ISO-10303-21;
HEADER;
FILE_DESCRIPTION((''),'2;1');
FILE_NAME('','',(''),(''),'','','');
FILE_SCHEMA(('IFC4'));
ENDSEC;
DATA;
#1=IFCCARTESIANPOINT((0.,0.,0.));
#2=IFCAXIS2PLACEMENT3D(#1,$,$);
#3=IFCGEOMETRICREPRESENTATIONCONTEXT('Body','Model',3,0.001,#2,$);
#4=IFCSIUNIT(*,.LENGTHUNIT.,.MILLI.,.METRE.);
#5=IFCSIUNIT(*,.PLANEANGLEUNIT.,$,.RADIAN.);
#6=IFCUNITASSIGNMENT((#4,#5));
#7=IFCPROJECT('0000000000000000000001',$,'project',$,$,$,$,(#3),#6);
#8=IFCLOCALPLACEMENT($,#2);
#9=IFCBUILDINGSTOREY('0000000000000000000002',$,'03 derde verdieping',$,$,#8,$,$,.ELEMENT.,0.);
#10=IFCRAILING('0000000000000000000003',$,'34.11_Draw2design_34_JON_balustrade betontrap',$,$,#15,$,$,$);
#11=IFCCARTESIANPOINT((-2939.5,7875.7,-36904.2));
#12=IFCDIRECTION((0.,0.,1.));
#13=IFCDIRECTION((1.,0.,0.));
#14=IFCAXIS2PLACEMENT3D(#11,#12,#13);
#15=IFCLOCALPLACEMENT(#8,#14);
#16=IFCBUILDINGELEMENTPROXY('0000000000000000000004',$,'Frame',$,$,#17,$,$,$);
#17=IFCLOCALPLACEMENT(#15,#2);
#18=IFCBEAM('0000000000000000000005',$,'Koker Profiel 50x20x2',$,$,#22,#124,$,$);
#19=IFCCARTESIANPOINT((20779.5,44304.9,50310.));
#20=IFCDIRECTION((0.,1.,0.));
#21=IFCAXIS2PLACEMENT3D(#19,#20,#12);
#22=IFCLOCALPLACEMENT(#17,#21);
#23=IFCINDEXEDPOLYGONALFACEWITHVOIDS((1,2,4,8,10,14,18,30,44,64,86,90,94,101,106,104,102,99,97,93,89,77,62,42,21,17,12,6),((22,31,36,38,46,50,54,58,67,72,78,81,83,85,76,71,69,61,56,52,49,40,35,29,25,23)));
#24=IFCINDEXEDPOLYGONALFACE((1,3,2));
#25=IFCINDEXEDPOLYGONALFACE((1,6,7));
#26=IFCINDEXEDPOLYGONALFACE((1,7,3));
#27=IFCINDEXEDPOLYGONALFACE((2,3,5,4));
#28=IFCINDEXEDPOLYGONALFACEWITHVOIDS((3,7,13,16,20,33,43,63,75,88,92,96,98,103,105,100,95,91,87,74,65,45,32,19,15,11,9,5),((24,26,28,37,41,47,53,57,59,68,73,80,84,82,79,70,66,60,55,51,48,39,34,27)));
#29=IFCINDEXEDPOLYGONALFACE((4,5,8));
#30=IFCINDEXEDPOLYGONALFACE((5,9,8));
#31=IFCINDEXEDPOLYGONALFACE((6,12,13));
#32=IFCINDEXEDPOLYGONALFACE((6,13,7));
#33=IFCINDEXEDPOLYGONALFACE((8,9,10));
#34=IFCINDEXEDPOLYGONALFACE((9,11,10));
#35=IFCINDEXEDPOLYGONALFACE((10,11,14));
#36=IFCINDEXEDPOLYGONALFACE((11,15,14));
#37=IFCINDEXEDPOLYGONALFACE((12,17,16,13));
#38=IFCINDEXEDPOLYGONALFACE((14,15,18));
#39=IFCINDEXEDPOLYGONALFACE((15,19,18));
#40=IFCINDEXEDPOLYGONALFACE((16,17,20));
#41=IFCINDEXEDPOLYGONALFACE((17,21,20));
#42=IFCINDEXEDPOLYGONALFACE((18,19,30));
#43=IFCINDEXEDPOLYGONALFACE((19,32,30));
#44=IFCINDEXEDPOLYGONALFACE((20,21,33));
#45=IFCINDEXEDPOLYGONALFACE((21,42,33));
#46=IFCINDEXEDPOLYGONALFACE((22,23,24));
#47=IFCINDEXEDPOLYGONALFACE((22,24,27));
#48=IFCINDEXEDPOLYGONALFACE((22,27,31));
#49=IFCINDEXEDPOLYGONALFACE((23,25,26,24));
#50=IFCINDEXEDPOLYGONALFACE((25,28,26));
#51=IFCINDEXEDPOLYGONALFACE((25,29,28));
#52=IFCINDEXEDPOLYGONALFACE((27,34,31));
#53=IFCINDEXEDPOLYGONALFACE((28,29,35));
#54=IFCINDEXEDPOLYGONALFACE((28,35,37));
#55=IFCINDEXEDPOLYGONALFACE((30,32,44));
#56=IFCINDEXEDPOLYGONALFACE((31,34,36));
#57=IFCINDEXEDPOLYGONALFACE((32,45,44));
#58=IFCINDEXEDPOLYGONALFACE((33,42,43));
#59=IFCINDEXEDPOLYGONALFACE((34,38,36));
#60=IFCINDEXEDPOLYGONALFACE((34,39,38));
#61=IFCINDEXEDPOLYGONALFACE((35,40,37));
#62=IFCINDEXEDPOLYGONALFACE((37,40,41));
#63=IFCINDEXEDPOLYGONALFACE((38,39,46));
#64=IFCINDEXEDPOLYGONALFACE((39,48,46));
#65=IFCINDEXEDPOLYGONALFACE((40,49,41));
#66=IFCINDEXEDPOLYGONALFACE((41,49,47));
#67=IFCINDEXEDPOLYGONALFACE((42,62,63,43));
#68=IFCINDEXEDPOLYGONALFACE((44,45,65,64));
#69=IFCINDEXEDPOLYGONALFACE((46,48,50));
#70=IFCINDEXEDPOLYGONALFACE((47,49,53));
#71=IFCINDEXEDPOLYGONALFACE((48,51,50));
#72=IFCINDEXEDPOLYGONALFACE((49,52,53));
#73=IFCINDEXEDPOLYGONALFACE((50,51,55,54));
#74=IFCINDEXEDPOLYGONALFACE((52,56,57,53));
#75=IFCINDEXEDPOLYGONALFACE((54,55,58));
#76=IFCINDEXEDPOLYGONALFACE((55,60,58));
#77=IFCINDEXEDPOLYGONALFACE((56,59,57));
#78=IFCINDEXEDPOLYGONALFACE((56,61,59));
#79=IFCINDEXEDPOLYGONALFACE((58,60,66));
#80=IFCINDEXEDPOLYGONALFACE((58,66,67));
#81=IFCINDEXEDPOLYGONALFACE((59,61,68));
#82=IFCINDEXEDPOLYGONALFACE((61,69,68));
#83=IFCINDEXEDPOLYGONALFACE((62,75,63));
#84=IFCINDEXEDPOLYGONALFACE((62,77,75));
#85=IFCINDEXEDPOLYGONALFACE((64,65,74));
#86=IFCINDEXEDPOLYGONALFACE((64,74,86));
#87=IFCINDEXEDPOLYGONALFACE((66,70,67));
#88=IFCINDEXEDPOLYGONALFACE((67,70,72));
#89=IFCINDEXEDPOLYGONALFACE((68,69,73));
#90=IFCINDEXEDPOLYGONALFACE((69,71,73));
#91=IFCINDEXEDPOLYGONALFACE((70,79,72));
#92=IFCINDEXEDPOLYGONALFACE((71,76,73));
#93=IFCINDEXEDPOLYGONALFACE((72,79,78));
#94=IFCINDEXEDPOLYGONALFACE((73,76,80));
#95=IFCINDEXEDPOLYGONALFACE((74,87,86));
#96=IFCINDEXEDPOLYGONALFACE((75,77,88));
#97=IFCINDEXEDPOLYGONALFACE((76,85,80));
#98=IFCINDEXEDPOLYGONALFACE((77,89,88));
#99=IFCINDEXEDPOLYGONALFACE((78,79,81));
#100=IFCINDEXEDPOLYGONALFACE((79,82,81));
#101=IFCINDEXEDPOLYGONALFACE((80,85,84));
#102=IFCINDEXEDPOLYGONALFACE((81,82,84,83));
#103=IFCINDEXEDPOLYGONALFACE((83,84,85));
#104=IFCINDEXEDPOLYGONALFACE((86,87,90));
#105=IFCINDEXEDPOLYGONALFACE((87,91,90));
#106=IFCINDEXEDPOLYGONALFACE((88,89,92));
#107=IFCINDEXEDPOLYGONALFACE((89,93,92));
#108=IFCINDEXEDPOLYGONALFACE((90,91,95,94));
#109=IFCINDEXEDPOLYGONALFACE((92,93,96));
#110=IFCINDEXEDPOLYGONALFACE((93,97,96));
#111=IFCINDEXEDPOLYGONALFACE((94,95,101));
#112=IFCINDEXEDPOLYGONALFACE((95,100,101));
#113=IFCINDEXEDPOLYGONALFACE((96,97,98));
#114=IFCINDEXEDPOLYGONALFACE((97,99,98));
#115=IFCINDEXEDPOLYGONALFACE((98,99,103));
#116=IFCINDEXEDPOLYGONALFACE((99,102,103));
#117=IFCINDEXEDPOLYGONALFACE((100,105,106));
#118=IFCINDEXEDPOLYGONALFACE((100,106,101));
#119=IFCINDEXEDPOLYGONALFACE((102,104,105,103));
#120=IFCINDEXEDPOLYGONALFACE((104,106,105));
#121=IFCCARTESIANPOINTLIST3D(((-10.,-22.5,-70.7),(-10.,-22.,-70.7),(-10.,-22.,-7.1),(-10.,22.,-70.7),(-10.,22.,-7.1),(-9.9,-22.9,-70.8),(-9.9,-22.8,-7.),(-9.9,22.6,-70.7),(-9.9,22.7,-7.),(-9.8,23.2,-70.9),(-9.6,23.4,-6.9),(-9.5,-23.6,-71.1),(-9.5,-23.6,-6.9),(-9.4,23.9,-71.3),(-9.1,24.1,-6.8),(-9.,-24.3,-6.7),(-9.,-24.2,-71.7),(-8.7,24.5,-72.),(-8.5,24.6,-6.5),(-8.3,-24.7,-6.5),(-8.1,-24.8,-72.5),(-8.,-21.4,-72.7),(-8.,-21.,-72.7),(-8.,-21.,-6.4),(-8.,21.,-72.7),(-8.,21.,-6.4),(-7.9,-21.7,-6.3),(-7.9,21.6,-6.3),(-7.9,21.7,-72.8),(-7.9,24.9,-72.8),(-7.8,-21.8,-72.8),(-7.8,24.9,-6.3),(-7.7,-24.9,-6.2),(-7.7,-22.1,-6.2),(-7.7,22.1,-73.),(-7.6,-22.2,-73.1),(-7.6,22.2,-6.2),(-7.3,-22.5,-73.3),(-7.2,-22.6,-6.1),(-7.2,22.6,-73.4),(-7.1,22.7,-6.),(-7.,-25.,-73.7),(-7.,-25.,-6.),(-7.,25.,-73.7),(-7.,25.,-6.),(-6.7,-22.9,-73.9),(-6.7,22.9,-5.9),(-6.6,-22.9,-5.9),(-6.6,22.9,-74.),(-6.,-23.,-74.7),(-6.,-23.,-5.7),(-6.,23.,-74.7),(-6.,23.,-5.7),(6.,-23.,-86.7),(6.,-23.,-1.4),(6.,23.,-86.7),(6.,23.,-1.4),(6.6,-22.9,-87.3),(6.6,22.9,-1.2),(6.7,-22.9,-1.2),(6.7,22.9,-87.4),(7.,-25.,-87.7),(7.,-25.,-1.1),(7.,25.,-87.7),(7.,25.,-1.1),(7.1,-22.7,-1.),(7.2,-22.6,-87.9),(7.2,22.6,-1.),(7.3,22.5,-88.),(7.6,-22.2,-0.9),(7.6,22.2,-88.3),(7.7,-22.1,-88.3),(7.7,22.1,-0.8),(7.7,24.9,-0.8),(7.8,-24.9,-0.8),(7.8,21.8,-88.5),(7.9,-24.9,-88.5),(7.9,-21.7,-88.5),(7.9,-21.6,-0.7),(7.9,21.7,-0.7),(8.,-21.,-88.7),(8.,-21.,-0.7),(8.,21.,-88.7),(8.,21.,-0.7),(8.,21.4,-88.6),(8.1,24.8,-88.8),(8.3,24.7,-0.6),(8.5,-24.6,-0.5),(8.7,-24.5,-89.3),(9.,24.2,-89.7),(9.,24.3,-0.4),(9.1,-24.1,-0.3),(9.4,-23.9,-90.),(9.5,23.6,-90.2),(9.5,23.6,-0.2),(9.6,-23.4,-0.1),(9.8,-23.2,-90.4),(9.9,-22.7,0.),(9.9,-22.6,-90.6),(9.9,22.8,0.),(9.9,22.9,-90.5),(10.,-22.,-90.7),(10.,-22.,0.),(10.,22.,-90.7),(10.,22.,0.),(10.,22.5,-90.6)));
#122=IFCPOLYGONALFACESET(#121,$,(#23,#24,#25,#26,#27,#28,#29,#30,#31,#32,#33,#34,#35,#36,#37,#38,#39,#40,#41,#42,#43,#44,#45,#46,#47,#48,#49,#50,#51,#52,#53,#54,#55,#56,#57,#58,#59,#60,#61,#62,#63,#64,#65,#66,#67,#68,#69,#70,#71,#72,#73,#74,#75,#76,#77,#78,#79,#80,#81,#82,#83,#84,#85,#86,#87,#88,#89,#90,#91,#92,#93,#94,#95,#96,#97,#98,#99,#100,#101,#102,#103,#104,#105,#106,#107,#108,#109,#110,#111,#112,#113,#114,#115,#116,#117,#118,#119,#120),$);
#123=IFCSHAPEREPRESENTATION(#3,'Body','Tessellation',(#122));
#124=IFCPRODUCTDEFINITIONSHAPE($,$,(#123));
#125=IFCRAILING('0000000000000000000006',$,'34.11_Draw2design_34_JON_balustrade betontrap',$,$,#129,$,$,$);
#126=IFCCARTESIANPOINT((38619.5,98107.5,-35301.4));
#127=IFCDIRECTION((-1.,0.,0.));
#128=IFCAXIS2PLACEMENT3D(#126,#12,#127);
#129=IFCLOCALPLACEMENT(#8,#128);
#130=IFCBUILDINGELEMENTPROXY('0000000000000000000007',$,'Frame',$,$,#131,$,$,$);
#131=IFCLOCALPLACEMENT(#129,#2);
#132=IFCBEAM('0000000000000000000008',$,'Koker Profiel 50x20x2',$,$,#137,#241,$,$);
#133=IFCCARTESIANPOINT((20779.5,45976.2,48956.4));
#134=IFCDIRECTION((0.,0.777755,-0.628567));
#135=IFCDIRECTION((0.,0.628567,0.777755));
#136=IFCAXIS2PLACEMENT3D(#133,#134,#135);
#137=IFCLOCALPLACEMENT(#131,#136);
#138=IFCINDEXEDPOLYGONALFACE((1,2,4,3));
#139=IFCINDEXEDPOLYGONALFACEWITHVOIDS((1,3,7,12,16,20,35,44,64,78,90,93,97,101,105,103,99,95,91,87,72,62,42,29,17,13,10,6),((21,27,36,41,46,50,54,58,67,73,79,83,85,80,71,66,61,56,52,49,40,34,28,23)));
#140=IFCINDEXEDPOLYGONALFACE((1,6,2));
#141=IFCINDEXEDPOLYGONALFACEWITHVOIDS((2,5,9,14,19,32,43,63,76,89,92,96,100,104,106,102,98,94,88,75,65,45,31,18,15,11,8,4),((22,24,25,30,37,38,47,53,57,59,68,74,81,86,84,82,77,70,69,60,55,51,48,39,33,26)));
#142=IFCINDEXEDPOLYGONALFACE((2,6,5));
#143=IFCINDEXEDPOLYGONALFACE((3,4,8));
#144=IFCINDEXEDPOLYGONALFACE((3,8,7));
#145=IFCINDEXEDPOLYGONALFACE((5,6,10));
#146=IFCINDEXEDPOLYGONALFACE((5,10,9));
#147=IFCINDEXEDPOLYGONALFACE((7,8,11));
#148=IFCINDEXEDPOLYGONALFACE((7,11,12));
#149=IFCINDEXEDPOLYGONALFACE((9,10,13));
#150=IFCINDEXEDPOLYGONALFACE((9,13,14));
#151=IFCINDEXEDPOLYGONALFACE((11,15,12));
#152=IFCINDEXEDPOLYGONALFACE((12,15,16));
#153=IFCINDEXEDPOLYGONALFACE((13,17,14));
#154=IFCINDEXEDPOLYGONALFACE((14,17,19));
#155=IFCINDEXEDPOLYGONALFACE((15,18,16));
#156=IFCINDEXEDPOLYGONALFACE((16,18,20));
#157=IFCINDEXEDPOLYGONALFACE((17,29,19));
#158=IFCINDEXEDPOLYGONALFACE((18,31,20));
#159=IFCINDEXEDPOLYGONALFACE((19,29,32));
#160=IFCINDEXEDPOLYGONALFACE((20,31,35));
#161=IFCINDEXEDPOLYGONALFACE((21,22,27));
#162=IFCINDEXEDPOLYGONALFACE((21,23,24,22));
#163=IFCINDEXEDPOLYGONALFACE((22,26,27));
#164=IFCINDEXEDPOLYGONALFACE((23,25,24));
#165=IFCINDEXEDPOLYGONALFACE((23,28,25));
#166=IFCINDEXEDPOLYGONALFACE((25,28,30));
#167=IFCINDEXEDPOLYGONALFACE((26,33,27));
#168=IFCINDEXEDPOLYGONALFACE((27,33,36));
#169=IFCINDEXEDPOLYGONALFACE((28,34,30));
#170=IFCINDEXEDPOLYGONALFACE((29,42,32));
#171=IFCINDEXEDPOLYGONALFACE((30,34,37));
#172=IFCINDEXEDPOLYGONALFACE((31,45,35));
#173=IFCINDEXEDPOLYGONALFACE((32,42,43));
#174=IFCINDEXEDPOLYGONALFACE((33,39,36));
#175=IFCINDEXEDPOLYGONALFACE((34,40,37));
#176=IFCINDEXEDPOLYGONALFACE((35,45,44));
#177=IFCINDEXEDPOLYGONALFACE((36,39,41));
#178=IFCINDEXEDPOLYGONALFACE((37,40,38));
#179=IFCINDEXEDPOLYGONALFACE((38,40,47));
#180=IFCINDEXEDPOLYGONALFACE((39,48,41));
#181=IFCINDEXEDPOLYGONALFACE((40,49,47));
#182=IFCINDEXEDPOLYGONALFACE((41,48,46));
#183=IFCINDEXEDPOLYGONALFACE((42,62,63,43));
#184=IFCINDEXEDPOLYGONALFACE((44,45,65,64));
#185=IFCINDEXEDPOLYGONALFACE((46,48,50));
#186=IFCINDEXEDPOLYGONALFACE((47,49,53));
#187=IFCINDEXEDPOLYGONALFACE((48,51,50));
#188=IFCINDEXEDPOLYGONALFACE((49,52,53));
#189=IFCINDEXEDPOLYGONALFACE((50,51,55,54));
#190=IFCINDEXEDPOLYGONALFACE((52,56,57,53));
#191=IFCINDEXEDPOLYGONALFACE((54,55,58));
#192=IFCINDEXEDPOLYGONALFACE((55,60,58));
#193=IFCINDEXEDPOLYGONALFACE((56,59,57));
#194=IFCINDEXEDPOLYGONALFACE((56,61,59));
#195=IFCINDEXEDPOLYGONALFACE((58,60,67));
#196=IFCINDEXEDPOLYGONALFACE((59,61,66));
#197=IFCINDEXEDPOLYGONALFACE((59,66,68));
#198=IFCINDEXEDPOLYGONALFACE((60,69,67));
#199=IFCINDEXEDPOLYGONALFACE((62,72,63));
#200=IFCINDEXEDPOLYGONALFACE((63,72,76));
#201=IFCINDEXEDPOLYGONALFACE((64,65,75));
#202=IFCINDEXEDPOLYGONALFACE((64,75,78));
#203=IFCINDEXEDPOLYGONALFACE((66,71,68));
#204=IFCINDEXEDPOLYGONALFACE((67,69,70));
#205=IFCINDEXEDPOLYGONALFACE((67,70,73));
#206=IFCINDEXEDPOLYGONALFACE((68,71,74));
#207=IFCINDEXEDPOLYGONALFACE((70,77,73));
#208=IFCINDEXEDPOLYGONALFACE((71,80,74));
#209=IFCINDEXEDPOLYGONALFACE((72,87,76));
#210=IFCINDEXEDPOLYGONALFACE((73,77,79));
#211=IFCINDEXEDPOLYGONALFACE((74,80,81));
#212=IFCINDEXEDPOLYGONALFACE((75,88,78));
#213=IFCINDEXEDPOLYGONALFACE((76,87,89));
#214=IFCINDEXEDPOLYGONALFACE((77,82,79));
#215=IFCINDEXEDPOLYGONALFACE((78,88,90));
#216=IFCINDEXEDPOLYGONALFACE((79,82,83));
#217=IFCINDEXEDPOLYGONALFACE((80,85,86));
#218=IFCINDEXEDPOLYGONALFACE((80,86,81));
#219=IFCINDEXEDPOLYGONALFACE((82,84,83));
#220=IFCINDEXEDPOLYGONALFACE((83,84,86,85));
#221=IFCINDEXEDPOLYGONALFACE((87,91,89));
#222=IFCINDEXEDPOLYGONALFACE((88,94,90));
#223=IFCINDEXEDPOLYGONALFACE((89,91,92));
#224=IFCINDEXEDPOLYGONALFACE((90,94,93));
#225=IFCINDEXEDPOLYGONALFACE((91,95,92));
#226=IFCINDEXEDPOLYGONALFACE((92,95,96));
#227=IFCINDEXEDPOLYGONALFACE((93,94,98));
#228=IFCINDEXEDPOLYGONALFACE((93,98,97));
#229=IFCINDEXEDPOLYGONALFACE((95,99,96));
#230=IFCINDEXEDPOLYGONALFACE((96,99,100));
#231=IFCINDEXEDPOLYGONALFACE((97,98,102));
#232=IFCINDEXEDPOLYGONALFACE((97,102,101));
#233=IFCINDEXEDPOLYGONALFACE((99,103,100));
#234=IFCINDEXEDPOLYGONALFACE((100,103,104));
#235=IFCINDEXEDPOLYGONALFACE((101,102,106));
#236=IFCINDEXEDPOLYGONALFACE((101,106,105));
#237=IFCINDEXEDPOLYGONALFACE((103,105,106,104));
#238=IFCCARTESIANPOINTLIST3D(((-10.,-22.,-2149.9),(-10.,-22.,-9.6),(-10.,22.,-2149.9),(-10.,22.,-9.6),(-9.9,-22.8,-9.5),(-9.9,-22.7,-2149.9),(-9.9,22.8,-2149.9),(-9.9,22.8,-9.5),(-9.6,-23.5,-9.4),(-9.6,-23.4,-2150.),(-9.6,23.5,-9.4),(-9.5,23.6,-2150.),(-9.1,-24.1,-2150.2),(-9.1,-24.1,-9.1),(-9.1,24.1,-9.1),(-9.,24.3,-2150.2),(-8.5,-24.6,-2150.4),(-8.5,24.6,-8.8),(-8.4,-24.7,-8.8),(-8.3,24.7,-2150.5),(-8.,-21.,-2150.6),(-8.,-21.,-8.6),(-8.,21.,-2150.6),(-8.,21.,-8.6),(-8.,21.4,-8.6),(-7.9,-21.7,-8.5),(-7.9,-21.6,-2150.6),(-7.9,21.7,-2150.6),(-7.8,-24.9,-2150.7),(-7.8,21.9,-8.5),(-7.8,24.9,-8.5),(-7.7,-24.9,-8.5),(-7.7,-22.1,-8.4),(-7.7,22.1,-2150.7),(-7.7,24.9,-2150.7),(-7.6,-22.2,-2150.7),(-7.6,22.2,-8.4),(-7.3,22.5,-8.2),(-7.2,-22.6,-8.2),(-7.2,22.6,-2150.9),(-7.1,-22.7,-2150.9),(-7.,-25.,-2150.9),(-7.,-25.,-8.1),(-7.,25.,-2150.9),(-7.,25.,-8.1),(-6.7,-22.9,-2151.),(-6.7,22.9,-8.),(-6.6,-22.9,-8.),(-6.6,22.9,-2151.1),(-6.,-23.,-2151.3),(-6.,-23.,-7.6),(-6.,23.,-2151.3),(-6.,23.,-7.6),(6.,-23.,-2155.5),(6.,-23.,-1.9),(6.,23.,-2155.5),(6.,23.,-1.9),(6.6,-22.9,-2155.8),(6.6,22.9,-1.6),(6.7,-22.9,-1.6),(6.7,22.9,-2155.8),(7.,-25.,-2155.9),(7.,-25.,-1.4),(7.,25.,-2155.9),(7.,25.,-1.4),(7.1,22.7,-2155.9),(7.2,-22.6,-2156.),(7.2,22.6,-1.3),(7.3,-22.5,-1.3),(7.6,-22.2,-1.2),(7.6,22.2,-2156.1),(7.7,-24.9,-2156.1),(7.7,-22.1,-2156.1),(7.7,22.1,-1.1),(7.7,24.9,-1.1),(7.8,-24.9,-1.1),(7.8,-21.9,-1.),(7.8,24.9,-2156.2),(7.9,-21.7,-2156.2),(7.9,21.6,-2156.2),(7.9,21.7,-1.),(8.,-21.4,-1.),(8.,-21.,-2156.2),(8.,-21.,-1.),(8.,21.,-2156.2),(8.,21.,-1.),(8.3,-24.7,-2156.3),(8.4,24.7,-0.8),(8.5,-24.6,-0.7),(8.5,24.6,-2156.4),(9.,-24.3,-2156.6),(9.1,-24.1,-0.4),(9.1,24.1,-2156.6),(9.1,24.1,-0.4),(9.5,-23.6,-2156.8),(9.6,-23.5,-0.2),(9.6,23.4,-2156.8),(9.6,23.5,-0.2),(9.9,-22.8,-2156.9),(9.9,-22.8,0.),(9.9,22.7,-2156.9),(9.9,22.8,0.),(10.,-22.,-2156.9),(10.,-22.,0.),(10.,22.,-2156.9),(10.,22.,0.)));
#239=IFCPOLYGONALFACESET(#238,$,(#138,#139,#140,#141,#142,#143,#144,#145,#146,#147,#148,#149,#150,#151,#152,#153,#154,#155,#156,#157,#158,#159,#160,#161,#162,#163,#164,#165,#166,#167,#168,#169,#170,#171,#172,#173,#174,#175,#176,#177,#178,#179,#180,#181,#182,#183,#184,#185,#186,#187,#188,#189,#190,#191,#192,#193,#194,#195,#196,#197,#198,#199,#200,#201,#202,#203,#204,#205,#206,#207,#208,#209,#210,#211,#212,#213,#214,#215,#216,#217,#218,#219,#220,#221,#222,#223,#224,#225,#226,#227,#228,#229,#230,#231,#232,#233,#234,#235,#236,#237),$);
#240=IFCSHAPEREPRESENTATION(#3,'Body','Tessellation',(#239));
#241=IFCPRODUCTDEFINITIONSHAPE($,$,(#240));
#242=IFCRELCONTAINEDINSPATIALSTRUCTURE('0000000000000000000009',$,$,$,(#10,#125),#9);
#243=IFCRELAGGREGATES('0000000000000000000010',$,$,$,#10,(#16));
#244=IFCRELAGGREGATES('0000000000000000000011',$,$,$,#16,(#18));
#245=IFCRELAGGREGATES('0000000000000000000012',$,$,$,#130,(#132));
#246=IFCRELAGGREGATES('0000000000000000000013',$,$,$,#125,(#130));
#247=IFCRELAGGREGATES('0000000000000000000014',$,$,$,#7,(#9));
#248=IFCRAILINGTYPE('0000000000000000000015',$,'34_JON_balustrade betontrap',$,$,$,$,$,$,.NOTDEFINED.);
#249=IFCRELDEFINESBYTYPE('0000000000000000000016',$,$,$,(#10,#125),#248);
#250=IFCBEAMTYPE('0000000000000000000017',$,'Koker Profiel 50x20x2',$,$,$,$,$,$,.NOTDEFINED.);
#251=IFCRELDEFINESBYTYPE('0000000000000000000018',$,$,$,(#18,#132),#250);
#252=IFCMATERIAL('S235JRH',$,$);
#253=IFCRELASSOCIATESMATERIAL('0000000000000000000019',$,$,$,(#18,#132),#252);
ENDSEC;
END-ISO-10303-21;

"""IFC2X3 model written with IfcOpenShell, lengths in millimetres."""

from ifc_helpers import new_model, si_unit, frame, origin, origin_2d, place, context, project, spatial, hollow_rectangle, extrude, clip, halfspace, source, transform, mapped, material, type_object, element, aggregate, save


model = new_model("IFC2X3")

# Units and contexts
model_context = context("Model", 3, precision=0.001, world=origin(), identifier="Body")
ifc_project = project(units=[si_unit("LENGTHUNIT", "METRE", prefix="MILLI"), si_unit("PLANEANGLEUNIT", "RADIAN")], contexts=[model_context])

# Storey
storey_placement = place(None, origin())
storey = spatial("IfcBuildingStorey", under=ifc_project, at=storey_placement, Name="03 derde verdieping", CompositionType="ELEMENT", Elevation=0.0)

# Railing, building element proxy, beam
railing_type_1 = type_object("IfcRailingType", Name="34_JON_balustrade betontrap")
railing_1_placement = place(storey_placement, frame((-2939.5, 7875.7, -36904.2), z_axis=(0.0, 0.0, 1.0), x_axis=(1.0, 0.0, 0.0)))
railing_1 = element("IfcRailing", 1, at=railing_1_placement, inside=storey, type_object=railing_type_1, Name="34.11_Draw2design_34_JON_balustrade betontrap")
ifc_material_1 = material(Name="S235JRH")
proxy_1_placement = place(railing_1_placement, origin())
proxy_1 = element("IfcBuildingElementProxy", 2, at=proxy_1_placement, Name="Frame")
aggregate(railing_1, [proxy_1])
beam_type_1 = type_object("IfcBeamType", Name="Koker Profiel 50x20x2")
shared_shape_1 = source(origin(), model_context, "Body", "Clipping", [
    clip(clip(extrude(hollow_rectangle(XDim=20.0, YDim=50.0, WallThickness=2.0, InnerFilletRadius=2.0, OuterFilletRadius=3.0, at=origin_2d()), origin(), (0.0, 0.0, -1.0), 90.7), halfspace(frame((-10.0, 25.0, -7.1), z_axis=(-0.33335, 0.0, 0.942803), x_axis=(0.0, 1.0, 0.0)), False)), halfspace(frame((-10.0, -25.0, -70.7), z_axis=(-0.707107, 0.0, -0.707107), x_axis=(0.0, -1.0, 0.0)), False)),
])
beam_1_placement = place(proxy_1_placement, frame((20779.5, 44304.9, 50310.0), z_axis=(0.0, 1.0, 0.0), x_axis=(0.0, 0.0, 1.0)))
beam_1 = element("IfcBeam", 3, at=beam_1_placement, type_object=beam_type_1, material=ifc_material_1, Name="Koker Profiel 50x20x2", context=model_context, shape_type="MappedRepresentation", body=[
    mapped(shared_shape_1, transform((0.0, 0.0, 0.0), scale=1.0)),
])

# Railing, building element proxy, beam
railing_2_placement = place(storey_placement, frame((38619.5, 98107.5, -35301.4), z_axis=(0.0, 0.0, 1.0), x_axis=(-1.0, 0.0, 0.0)))
railing_2 = element("IfcRailing", 4, at=railing_2_placement, inside=storey, type_object=railing_type_1, Name="34.11_Draw2design_34_JON_balustrade betontrap")
proxy_2_placement = place(railing_2_placement, origin())
proxy_2 = element("IfcBuildingElementProxy", 5, at=proxy_2_placement, Name="Frame")
shared_shape_2 = source(origin(), model_context, "Body", "Clipping", [
    clip(clip(extrude(hollow_rectangle(XDim=20.0, YDim=50.0, WallThickness=2.0, InnerFilletRadius=2.0, OuterFilletRadius=3.0, at=origin_2d()), origin(), (0.0, 0.0, -1.0), 2156.9), halfspace(frame((-10.0, 25.0, -9.6), z_axis=(-0.430948, 0.0, 0.902377), x_axis=(-0.902377, 0.0, -0.430948)), False)), halfspace(frame((-10.0, -25.0, -2149.9), z_axis=(-0.33335, 0.0, -0.942803), x_axis=(0.0, -1.0, 0.0)), False)),
])
beam_2_placement = place(proxy_2_placement, frame((20779.5, 45976.2, 48956.4), z_axis=(0.0, 0.777755, -0.628567), x_axis=(0.0, 0.628567, 0.777755)))
beam_2 = element("IfcBeam", 6, at=beam_2_placement, type_object=beam_type_1, material=ifc_material_1, Name="Koker Profiel 50x20x2", context=model_context, shape_type="MappedRepresentation", body=[
    mapped(shared_shape_2, transform((0.0, 0.0, 0.0), scale=1.0)),
])

aggregate(proxy_1, [beam_1])
aggregate(proxy_2, [beam_2])

aggregate(railing_2, [proxy_2])

save(model, "model.ifc")
